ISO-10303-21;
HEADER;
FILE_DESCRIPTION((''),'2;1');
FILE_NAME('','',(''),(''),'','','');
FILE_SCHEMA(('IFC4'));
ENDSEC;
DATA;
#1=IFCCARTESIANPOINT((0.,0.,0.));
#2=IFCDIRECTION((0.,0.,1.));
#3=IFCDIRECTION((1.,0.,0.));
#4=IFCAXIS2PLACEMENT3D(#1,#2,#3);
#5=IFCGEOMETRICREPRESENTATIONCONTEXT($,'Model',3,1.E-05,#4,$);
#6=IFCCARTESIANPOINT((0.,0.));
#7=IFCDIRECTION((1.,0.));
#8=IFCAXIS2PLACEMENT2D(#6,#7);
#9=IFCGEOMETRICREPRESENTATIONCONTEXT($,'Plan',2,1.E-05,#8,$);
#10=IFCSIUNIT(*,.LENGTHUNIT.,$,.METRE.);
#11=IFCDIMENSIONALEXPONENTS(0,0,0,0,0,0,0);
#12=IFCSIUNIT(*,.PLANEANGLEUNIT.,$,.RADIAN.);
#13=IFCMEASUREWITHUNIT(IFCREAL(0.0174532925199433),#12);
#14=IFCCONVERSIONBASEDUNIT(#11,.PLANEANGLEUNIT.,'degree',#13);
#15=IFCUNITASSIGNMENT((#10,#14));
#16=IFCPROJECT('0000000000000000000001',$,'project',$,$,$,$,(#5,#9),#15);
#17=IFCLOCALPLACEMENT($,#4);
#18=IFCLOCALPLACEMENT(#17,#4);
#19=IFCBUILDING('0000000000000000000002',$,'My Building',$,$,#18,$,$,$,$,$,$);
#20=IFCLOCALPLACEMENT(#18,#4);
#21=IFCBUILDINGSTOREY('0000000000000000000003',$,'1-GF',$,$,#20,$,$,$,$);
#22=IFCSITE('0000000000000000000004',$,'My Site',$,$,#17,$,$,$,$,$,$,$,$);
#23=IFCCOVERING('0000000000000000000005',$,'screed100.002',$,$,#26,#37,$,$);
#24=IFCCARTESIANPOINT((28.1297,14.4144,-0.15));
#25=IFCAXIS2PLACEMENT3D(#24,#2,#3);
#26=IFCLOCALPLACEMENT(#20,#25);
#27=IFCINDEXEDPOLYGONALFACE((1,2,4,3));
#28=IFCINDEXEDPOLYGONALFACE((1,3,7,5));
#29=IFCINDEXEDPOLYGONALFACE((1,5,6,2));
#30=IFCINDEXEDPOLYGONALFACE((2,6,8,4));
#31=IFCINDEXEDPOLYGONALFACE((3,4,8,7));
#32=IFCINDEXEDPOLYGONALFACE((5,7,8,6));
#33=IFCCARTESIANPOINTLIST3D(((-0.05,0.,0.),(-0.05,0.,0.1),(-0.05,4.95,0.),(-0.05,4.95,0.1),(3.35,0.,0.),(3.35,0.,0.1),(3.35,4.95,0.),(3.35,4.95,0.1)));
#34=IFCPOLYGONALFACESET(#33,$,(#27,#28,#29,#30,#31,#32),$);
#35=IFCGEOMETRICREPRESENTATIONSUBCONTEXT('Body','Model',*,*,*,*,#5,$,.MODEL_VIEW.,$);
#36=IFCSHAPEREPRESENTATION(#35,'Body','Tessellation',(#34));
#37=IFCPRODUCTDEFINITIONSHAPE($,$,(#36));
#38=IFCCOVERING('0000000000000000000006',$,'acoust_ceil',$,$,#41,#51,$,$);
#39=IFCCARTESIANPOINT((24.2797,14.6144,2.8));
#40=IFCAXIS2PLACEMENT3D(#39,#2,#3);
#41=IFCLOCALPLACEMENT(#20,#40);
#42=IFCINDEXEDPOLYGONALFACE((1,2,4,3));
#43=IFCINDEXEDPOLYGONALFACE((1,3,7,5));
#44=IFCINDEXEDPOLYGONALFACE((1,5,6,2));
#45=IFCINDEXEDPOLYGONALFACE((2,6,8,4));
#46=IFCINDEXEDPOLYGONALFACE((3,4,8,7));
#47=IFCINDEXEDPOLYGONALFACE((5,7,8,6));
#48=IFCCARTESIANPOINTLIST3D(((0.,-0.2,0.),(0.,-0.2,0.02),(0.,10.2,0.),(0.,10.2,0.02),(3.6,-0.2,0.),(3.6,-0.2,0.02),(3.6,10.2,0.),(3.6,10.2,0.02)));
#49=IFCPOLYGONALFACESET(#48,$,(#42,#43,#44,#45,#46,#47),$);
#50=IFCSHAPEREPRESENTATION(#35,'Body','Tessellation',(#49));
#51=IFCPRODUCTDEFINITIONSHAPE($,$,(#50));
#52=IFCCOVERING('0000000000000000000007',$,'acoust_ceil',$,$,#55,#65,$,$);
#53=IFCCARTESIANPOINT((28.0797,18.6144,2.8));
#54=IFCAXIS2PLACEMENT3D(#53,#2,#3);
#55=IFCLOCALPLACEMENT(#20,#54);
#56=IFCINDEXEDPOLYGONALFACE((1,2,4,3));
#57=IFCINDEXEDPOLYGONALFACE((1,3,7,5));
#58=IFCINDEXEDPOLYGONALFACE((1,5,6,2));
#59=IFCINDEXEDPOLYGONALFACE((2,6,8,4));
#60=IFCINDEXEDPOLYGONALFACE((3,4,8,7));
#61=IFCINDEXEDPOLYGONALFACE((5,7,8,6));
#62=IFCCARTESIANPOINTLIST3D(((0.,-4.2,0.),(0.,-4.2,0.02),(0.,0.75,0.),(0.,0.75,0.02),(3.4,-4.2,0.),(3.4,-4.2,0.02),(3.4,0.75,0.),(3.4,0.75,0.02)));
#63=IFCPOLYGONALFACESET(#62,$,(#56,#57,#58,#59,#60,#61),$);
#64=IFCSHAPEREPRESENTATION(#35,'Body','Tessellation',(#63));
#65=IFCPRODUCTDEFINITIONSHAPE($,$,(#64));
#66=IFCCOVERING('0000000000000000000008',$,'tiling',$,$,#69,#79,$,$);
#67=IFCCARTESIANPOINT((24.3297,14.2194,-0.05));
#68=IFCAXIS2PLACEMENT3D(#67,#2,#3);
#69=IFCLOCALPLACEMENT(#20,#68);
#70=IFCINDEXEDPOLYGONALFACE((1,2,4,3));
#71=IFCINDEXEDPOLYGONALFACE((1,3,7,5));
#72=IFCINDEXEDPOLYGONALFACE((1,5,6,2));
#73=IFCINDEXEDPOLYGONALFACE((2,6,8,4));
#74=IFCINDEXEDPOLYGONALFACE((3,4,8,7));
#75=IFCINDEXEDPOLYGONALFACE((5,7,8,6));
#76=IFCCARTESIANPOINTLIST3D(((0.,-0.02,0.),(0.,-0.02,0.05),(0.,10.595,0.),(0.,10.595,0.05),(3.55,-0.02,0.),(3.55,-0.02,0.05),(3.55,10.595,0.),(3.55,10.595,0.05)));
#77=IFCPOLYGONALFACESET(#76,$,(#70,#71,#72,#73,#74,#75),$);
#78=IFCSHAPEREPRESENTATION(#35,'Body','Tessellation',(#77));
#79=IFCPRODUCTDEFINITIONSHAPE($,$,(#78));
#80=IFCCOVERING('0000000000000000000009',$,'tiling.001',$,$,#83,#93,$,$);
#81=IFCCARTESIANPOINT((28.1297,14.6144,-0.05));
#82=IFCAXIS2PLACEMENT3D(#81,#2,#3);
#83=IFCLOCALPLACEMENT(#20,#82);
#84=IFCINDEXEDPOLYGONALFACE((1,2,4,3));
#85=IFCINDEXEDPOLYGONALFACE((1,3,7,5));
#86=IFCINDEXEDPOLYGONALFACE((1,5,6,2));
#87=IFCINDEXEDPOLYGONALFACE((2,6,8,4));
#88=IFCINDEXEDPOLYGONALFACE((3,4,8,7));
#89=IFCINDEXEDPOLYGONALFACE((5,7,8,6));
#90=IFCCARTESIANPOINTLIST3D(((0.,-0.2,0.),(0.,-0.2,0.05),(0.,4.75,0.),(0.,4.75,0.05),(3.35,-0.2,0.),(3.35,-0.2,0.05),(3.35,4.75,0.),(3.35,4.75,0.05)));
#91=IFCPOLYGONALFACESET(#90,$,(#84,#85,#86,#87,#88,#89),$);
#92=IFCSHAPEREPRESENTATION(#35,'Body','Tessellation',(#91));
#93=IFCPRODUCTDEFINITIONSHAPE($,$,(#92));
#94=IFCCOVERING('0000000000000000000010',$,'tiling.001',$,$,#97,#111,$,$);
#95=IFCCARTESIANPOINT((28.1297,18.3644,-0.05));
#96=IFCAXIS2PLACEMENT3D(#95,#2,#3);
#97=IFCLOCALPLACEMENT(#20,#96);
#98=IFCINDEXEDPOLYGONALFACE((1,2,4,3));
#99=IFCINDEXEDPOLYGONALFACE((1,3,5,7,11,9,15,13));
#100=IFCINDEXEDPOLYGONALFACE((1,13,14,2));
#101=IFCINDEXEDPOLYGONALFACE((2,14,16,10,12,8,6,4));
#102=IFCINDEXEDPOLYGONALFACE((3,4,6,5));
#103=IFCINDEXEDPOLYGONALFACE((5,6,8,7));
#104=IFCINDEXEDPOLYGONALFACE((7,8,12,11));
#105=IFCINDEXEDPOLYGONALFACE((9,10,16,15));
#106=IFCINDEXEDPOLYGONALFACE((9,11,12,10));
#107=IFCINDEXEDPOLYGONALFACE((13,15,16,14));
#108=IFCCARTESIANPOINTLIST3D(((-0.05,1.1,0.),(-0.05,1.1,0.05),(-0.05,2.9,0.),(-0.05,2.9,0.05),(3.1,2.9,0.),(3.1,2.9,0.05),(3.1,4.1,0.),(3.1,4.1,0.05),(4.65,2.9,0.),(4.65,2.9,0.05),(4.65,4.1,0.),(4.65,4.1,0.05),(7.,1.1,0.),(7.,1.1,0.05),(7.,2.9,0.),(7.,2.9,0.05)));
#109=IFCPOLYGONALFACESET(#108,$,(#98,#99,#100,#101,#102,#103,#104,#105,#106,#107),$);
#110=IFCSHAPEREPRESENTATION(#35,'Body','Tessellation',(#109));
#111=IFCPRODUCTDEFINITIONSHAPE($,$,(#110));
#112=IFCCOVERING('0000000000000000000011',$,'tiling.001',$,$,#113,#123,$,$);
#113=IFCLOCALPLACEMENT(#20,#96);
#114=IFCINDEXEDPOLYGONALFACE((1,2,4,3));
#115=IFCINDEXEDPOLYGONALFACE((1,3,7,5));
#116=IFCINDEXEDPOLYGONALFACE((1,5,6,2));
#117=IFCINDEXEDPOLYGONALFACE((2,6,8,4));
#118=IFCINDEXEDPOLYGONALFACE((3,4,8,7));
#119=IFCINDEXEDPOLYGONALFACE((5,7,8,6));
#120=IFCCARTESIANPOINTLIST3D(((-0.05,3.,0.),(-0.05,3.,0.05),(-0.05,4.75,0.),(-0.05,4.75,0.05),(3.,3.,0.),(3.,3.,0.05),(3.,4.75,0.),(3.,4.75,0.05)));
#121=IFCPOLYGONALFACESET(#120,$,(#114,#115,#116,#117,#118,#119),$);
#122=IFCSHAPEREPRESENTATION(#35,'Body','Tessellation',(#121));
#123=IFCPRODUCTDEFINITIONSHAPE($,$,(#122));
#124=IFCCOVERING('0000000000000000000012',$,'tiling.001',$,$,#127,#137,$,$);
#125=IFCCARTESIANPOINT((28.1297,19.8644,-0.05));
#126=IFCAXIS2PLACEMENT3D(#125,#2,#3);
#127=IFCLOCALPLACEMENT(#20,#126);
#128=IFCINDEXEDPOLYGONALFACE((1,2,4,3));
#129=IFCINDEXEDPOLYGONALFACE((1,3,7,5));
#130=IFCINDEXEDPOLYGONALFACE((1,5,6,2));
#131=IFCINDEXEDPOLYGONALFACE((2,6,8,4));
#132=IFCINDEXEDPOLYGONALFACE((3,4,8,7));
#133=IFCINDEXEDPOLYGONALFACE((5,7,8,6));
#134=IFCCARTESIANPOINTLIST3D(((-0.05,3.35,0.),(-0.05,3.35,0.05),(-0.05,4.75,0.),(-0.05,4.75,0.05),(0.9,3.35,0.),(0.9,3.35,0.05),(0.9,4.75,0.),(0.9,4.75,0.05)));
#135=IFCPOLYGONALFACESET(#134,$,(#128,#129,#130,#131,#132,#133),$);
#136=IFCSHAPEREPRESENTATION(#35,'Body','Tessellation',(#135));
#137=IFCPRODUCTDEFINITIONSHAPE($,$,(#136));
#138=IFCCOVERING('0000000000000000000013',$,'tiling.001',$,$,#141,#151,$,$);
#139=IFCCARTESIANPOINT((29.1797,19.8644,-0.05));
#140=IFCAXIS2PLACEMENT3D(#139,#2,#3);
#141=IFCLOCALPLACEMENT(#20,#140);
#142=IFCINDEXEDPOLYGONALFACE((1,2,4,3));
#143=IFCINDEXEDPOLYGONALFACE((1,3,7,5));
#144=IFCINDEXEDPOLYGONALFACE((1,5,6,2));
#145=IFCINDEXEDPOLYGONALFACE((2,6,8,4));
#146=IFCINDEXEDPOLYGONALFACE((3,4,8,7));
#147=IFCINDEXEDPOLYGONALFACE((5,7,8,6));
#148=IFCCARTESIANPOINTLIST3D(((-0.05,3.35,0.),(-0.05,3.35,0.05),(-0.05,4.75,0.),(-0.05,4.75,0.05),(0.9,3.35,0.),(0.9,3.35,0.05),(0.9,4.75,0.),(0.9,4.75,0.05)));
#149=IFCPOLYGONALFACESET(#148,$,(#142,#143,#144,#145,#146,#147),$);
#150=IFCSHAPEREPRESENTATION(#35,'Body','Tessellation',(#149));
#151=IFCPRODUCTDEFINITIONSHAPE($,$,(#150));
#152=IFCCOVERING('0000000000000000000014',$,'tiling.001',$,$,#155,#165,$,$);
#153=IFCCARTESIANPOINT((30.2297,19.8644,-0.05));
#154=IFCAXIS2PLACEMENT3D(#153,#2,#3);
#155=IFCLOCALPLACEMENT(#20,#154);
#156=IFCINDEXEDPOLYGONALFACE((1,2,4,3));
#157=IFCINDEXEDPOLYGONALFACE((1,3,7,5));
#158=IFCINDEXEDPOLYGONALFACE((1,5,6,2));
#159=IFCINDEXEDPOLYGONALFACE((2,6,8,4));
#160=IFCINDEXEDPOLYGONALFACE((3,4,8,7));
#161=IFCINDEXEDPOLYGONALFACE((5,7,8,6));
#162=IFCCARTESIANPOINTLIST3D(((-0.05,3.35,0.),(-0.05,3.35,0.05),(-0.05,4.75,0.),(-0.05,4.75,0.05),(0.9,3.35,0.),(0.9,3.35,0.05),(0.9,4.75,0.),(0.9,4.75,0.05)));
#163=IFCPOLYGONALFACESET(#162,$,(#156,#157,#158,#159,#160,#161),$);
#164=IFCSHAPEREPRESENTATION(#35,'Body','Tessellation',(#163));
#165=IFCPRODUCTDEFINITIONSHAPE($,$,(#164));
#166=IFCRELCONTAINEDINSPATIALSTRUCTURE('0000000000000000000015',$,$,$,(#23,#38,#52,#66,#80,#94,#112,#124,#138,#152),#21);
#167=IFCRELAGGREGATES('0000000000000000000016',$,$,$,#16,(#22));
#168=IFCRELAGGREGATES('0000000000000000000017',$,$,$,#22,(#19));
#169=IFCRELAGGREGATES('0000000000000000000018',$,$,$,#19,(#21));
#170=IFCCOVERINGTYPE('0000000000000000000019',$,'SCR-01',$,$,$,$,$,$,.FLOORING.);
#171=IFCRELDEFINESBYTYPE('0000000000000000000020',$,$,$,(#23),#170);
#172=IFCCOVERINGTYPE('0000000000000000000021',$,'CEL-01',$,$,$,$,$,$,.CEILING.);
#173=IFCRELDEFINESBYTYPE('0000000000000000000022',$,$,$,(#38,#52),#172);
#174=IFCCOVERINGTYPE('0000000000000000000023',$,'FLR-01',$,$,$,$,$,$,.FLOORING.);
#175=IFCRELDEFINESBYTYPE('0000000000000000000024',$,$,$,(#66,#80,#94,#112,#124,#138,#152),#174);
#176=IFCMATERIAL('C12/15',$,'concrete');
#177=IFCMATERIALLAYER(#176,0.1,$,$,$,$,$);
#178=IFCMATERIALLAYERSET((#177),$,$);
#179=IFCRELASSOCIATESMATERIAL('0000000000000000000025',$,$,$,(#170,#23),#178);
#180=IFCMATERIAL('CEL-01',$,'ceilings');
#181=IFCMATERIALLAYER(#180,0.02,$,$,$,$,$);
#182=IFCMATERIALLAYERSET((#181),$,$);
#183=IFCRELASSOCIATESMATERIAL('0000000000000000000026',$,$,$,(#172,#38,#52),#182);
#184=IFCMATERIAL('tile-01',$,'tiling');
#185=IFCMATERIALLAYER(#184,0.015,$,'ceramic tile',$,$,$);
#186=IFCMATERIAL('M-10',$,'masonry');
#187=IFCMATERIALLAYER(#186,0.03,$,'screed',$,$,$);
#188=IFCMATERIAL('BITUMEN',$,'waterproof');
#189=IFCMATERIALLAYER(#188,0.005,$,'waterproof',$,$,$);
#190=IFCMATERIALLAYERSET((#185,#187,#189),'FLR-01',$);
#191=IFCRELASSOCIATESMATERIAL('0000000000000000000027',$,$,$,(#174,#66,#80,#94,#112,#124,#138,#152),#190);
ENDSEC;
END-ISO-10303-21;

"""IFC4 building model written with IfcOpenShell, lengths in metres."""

from ifc_helpers import new_model, entity, si_unit, converted_unit, frame, origin_with_axes, origin_2d_with_axis, place, context, subcontext, project, spatial, line, indexed_curve, outline, extrude, material, layer, layer_set, layer_usage, type_object, element, save


model = new_model("IFC4")

# Units and contexts
model_context = context("Model", 3, precision=1e-05, world=origin_with_axes())
plan_context = context("Plan", 2, precision=1e-05, world=origin_2d_with_axis())
body_context_1 = subcontext(model_context, "Body", "Model", "MODEL_VIEW")
ifc_project = project(units=[si_unit("LENGTHUNIT", "METRE"), converted_unit("PLANEANGLEUNIT", "degree", entity("IfcReal", 0.0174532925199433), si_unit("PLANEANGLEUNIT", "RADIAN"), dimensions=[0, 0, 0, 0, 0, 0, 0])], contexts=[model_context, plan_context])

# Site, building, storey
site_placement = place(None, origin_with_axes())
site = spatial("IfcSite", under=ifc_project, at=site_placement, Name="My Site")
building_placement = place(site_placement, origin_with_axes())
building = spatial("IfcBuilding", under=site, at=building_placement, Name="My Building")
storey_placement = place(building_placement, origin_with_axes())
storey = spatial("IfcBuildingStorey", under=building, at=storey_placement, Name="1-GF")

# Coverings
ifc_material_1 = material(Name="C12/15", Category="concrete")
ifc_layer_1 = layer(ifc_material_1, 0.1)
ifc_layer_set_1 = layer_set([ifc_layer_1])
covering_type_1 = type_object("IfcCoveringType", Name="SCR-01", PredefinedType="FLOORING", material=ifc_layer_set_1)
ifc_layer_usage_1 = layer_usage(ifc_layer_set_1, "AXIS3", "POSITIVE", 0.0)
covering_1_placement = place(storey_placement, frame((28.1297, 14.4144, -0.15), z_axis=(0.0, 0.0, 1.0), x_axis=(1.0, 0.0, 0.0)))
element("IfcCovering", 1, at=covering_1_placement, inside=storey, type_object=covering_type_1, material=ifc_layer_usage_1, Name="screed100.002", context=body_context_1, shape_type="SweptSolid", body=[
    extrude(outline(indexed_curve([(-0.05, 0.0), (3.35, 0.0), (3.35, 4.95), (-0.05, 4.95)], segments=[line(3, 2), line(2, 1), line(1, 4), line(4, 3)], self_intersect=False)), None, (0.0, 0.0, 1.0), 0.1),
])
ifc_material_2 = material(Name="CEL-01", Category="ceilings")
ifc_layer_2 = layer(ifc_material_2, 0.02)
ifc_layer_set_2 = layer_set([ifc_layer_2])
ifc_layer_usage_2 = layer_usage(ifc_layer_set_2, "AXIS3", "POSITIVE", 0.0)
covering_type_2 = type_object("IfcCoveringType", Name="CEL-01", PredefinedType="CEILING", material=ifc_layer_set_2)
covering_2_placement = place(storey_placement, frame((24.2797, 14.6144, 2.8), z_axis=(0.0, 0.0, 1.0), x_axis=(1.0, 0.0, 0.0)))
element("IfcCovering", 2, at=covering_2_placement, inside=storey, type_object=covering_type_2, material=ifc_layer_usage_2, Name="acoust_ceil", context=body_context_1, shape_type="SweptSolid", body=[
    extrude(outline(indexed_curve([(3.6, 10.2), (3.6, -0.2), (0.0, -0.2), (0.0, 10.2)], segments=[line(3, 2), line(2, 1), line(1, 4), line(4, 3)], self_intersect=False)), None, (0.0, 0.0, 1.0), 0.02),
])
ifc_layer_usage_3 = layer_usage(ifc_layer_set_2, "AXIS3", "POSITIVE", 0.0)
covering_3_placement = place(storey_placement, frame((28.0797, 18.6144, 2.8), z_axis=(0.0, 0.0, 1.0), x_axis=(1.0, 0.0, 0.0)))
element("IfcCovering", 3, at=covering_3_placement, inside=storey, type_object=covering_type_2, material=ifc_layer_usage_3, Name="acoust_ceil", context=body_context_1, shape_type="SweptSolid", body=[
    extrude(outline(indexed_curve([(0.0, -4.2), (3.4, -4.2), (3.4, 0.75), (0.0, 0.75)], segments=[line(3, 2), line(2, 1), line(1, 4), line(4, 3)], self_intersect=False)), None, (0.0, 0.0, 1.0), 0.02),
])
ifc_material_3 = material(Name="tile-01", Category="tiling")
ifc_layer_3 = layer(ifc_material_3, 0.015, Name="ceramic tile")
ifc_material_4 = material(Name="M-10", Category="masonry")
ifc_layer_4 = layer(ifc_material_4, 0.03, Name="screed")
ifc_material_5 = material(Name="BITUMEN", Category="waterproof")
ifc_layer_5 = layer(ifc_material_5, 0.005, Name="waterproof")
ifc_layer_set_3 = layer_set([ifc_layer_3, ifc_layer_4, ifc_layer_5], Name="FLR-01")
ifc_layer_usage_4 = layer_usage(ifc_layer_set_3, "AXIS3", "POSITIVE", 0.0)
covering_type_3 = type_object("IfcCoveringType", Name="FLR-01", PredefinedType="FLOORING", material=ifc_layer_set_3)
covering_4_placement = place(storey_placement, frame((24.3297, 14.2194, -0.05), z_axis=(0.0, 0.0, 1.0), x_axis=(1.0, 0.0, 0.0)))
element("IfcCovering", 4, at=covering_4_placement, inside=storey, type_object=covering_type_3, material=ifc_layer_usage_4, Name="tiling", context=body_context_1, shape_type="SweptSolid", body=[
    extrude(outline(indexed_curve([(3.55, 10.595), (3.55, -0.02), (0.0, -0.02), (0.0, 10.595)], segments=[line(4, 1), line(1, 2), line(2, 3), line(3, 4)], self_intersect=False)), None, (0.0, 0.0, 1.0), 0.05),
])
ifc_layer_usage_5 = layer_usage(ifc_layer_set_3, "AXIS3", "POSITIVE", 0.0)
covering_5_placement = place(storey_placement, frame((28.1297, 14.6144, -0.05), z_axis=(0.0, 0.0, 1.0), x_axis=(1.0, 0.0, 0.0)))
element("IfcCovering", 5, at=covering_5_placement, inside=storey, type_object=covering_type_3, material=ifc_layer_usage_5, Name="tiling.001", context=body_context_1, shape_type="SweptSolid", body=[
    extrude(outline(indexed_curve([(0.0, 4.75), (0.0, -0.2), (3.35, -0.2), (3.35, 4.75)], segments=[line(3, 2), line(2, 1), line(1, 4), line(4, 3)], self_intersect=False)), None, (0.0, 0.0, 1.0), 0.05),
])
ifc_layer_usage_6 = layer_usage(ifc_layer_set_3, "AXIS3", "POSITIVE", 0.0)
covering_6_placement = place(storey_placement, frame((28.1297, 18.3644, -0.05), z_axis=(0.0, 0.0, 1.0), x_axis=(1.0, 0.0, 0.0)))
element("IfcCovering", 6, at=covering_6_placement, inside=storey, type_object=covering_type_3, material=ifc_layer_usage_6, Name="tiling.001", context=body_context_1, shape_type="SweptSolid", body=[
    extrude(outline(indexed_curve([(7.0, 1.1), (-0.05, 1.1), (-0.05, 2.9), (7.0, 2.9), (3.1, 2.9), (4.65, 2.9), (3.1, 4.1), (4.65, 4.1)], segments=[line(6, 4), line(4, 1), line(1, 2), line(2, 3), line(3, 5), line(5, 7), line(7, 8), line(8, 6)], self_intersect=False)), None, (0.0, 0.0, 1.0), 0.05),
])
ifc_layer_usage_7 = layer_usage(ifc_layer_set_3, "AXIS3", "POSITIVE", 0.0)
covering_7_placement = place(storey_placement, frame((28.1297, 18.3644, -0.05), z_axis=(0.0, 0.0, 1.0), x_axis=(1.0, 0.0, 0.0)))
element("IfcCovering", 7, at=covering_7_placement, inside=storey, type_object=covering_type_3, material=ifc_layer_usage_7, Name="tiling.001", context=body_context_1, shape_type="SweptSolid", body=[
    extrude(outline(indexed_curve([(3.0, 3.0), (-0.05, 3.0), (-0.05, 4.75), (3.0, 4.75)], segments=[line(4, 1), line(1, 2), line(2, 3), line(3, 4)], self_intersect=False)), None, (0.0, 0.0, 1.0), 0.05),
])
ifc_layer_usage_8 = layer_usage(ifc_layer_set_3, "AXIS3", "POSITIVE", 0.0)
covering_8_placement = place(storey_placement, frame((28.1297, 19.8644, -0.05), z_axis=(0.0, 0.0, 1.0), x_axis=(1.0, 0.0, 0.0)))
element("IfcCovering", 8, at=covering_8_placement, inside=storey, type_object=covering_type_3, material=ifc_layer_usage_8, Name="tiling.001", context=body_context_1, shape_type="SweptSolid", body=[
    extrude(outline(indexed_curve([(0.9, 4.75), (0.9, 3.35), (-0.05, 3.35), (-0.05, 4.75)], segments=[line(4, 1), line(1, 2), line(2, 3), line(3, 4)], self_intersect=False)), None, (0.0, 0.0, 1.0), 0.05),
])
ifc_layer_usage_9 = layer_usage(ifc_layer_set_3, "AXIS3", "POSITIVE", 0.0)
covering_9_placement = place(storey_placement, frame((29.1797, 19.8644, -0.05), z_axis=(0.0, 0.0, 1.0), x_axis=(1.0, 0.0, 0.0)))
element("IfcCovering", 9, at=covering_9_placement, inside=storey, type_object=covering_type_3, material=ifc_layer_usage_9, Name="tiling.001", context=body_context_1, shape_type="SweptSolid", body=[
    extrude(outline(indexed_curve([(0.9, 4.75), (0.9, 3.35), (-0.05, 3.35), (-0.05, 4.75)], segments=[line(4, 1), line(1, 2), line(2, 3), line(3, 4)], self_intersect=False)), None, (0.0, 0.0, 1.0), 0.05),
])
ifc_layer_usage_10 = layer_usage(ifc_layer_set_3, "AXIS3", "POSITIVE", 0.0)
covering_10_placement = place(storey_placement, frame((30.2297, 19.8644, -0.05), z_axis=(0.0, 0.0, 1.0), x_axis=(1.0, 0.0, 0.0)))
element("IfcCovering", 10, at=covering_10_placement, inside=storey, type_object=covering_type_3, material=ifc_layer_usage_10, Name="tiling.001", context=body_context_1, shape_type="SweptSolid", body=[
    extrude(outline(indexed_curve([(0.9, 4.75), (0.9, 3.35), (-0.05, 3.35), (-0.05, 4.75)], segments=[line(4, 1), line(1, 2), line(2, 3), line(3, 4)], self_intersect=False)), None, (0.0, 0.0, 1.0), 0.05),
])

save(model, "model.ifc")
